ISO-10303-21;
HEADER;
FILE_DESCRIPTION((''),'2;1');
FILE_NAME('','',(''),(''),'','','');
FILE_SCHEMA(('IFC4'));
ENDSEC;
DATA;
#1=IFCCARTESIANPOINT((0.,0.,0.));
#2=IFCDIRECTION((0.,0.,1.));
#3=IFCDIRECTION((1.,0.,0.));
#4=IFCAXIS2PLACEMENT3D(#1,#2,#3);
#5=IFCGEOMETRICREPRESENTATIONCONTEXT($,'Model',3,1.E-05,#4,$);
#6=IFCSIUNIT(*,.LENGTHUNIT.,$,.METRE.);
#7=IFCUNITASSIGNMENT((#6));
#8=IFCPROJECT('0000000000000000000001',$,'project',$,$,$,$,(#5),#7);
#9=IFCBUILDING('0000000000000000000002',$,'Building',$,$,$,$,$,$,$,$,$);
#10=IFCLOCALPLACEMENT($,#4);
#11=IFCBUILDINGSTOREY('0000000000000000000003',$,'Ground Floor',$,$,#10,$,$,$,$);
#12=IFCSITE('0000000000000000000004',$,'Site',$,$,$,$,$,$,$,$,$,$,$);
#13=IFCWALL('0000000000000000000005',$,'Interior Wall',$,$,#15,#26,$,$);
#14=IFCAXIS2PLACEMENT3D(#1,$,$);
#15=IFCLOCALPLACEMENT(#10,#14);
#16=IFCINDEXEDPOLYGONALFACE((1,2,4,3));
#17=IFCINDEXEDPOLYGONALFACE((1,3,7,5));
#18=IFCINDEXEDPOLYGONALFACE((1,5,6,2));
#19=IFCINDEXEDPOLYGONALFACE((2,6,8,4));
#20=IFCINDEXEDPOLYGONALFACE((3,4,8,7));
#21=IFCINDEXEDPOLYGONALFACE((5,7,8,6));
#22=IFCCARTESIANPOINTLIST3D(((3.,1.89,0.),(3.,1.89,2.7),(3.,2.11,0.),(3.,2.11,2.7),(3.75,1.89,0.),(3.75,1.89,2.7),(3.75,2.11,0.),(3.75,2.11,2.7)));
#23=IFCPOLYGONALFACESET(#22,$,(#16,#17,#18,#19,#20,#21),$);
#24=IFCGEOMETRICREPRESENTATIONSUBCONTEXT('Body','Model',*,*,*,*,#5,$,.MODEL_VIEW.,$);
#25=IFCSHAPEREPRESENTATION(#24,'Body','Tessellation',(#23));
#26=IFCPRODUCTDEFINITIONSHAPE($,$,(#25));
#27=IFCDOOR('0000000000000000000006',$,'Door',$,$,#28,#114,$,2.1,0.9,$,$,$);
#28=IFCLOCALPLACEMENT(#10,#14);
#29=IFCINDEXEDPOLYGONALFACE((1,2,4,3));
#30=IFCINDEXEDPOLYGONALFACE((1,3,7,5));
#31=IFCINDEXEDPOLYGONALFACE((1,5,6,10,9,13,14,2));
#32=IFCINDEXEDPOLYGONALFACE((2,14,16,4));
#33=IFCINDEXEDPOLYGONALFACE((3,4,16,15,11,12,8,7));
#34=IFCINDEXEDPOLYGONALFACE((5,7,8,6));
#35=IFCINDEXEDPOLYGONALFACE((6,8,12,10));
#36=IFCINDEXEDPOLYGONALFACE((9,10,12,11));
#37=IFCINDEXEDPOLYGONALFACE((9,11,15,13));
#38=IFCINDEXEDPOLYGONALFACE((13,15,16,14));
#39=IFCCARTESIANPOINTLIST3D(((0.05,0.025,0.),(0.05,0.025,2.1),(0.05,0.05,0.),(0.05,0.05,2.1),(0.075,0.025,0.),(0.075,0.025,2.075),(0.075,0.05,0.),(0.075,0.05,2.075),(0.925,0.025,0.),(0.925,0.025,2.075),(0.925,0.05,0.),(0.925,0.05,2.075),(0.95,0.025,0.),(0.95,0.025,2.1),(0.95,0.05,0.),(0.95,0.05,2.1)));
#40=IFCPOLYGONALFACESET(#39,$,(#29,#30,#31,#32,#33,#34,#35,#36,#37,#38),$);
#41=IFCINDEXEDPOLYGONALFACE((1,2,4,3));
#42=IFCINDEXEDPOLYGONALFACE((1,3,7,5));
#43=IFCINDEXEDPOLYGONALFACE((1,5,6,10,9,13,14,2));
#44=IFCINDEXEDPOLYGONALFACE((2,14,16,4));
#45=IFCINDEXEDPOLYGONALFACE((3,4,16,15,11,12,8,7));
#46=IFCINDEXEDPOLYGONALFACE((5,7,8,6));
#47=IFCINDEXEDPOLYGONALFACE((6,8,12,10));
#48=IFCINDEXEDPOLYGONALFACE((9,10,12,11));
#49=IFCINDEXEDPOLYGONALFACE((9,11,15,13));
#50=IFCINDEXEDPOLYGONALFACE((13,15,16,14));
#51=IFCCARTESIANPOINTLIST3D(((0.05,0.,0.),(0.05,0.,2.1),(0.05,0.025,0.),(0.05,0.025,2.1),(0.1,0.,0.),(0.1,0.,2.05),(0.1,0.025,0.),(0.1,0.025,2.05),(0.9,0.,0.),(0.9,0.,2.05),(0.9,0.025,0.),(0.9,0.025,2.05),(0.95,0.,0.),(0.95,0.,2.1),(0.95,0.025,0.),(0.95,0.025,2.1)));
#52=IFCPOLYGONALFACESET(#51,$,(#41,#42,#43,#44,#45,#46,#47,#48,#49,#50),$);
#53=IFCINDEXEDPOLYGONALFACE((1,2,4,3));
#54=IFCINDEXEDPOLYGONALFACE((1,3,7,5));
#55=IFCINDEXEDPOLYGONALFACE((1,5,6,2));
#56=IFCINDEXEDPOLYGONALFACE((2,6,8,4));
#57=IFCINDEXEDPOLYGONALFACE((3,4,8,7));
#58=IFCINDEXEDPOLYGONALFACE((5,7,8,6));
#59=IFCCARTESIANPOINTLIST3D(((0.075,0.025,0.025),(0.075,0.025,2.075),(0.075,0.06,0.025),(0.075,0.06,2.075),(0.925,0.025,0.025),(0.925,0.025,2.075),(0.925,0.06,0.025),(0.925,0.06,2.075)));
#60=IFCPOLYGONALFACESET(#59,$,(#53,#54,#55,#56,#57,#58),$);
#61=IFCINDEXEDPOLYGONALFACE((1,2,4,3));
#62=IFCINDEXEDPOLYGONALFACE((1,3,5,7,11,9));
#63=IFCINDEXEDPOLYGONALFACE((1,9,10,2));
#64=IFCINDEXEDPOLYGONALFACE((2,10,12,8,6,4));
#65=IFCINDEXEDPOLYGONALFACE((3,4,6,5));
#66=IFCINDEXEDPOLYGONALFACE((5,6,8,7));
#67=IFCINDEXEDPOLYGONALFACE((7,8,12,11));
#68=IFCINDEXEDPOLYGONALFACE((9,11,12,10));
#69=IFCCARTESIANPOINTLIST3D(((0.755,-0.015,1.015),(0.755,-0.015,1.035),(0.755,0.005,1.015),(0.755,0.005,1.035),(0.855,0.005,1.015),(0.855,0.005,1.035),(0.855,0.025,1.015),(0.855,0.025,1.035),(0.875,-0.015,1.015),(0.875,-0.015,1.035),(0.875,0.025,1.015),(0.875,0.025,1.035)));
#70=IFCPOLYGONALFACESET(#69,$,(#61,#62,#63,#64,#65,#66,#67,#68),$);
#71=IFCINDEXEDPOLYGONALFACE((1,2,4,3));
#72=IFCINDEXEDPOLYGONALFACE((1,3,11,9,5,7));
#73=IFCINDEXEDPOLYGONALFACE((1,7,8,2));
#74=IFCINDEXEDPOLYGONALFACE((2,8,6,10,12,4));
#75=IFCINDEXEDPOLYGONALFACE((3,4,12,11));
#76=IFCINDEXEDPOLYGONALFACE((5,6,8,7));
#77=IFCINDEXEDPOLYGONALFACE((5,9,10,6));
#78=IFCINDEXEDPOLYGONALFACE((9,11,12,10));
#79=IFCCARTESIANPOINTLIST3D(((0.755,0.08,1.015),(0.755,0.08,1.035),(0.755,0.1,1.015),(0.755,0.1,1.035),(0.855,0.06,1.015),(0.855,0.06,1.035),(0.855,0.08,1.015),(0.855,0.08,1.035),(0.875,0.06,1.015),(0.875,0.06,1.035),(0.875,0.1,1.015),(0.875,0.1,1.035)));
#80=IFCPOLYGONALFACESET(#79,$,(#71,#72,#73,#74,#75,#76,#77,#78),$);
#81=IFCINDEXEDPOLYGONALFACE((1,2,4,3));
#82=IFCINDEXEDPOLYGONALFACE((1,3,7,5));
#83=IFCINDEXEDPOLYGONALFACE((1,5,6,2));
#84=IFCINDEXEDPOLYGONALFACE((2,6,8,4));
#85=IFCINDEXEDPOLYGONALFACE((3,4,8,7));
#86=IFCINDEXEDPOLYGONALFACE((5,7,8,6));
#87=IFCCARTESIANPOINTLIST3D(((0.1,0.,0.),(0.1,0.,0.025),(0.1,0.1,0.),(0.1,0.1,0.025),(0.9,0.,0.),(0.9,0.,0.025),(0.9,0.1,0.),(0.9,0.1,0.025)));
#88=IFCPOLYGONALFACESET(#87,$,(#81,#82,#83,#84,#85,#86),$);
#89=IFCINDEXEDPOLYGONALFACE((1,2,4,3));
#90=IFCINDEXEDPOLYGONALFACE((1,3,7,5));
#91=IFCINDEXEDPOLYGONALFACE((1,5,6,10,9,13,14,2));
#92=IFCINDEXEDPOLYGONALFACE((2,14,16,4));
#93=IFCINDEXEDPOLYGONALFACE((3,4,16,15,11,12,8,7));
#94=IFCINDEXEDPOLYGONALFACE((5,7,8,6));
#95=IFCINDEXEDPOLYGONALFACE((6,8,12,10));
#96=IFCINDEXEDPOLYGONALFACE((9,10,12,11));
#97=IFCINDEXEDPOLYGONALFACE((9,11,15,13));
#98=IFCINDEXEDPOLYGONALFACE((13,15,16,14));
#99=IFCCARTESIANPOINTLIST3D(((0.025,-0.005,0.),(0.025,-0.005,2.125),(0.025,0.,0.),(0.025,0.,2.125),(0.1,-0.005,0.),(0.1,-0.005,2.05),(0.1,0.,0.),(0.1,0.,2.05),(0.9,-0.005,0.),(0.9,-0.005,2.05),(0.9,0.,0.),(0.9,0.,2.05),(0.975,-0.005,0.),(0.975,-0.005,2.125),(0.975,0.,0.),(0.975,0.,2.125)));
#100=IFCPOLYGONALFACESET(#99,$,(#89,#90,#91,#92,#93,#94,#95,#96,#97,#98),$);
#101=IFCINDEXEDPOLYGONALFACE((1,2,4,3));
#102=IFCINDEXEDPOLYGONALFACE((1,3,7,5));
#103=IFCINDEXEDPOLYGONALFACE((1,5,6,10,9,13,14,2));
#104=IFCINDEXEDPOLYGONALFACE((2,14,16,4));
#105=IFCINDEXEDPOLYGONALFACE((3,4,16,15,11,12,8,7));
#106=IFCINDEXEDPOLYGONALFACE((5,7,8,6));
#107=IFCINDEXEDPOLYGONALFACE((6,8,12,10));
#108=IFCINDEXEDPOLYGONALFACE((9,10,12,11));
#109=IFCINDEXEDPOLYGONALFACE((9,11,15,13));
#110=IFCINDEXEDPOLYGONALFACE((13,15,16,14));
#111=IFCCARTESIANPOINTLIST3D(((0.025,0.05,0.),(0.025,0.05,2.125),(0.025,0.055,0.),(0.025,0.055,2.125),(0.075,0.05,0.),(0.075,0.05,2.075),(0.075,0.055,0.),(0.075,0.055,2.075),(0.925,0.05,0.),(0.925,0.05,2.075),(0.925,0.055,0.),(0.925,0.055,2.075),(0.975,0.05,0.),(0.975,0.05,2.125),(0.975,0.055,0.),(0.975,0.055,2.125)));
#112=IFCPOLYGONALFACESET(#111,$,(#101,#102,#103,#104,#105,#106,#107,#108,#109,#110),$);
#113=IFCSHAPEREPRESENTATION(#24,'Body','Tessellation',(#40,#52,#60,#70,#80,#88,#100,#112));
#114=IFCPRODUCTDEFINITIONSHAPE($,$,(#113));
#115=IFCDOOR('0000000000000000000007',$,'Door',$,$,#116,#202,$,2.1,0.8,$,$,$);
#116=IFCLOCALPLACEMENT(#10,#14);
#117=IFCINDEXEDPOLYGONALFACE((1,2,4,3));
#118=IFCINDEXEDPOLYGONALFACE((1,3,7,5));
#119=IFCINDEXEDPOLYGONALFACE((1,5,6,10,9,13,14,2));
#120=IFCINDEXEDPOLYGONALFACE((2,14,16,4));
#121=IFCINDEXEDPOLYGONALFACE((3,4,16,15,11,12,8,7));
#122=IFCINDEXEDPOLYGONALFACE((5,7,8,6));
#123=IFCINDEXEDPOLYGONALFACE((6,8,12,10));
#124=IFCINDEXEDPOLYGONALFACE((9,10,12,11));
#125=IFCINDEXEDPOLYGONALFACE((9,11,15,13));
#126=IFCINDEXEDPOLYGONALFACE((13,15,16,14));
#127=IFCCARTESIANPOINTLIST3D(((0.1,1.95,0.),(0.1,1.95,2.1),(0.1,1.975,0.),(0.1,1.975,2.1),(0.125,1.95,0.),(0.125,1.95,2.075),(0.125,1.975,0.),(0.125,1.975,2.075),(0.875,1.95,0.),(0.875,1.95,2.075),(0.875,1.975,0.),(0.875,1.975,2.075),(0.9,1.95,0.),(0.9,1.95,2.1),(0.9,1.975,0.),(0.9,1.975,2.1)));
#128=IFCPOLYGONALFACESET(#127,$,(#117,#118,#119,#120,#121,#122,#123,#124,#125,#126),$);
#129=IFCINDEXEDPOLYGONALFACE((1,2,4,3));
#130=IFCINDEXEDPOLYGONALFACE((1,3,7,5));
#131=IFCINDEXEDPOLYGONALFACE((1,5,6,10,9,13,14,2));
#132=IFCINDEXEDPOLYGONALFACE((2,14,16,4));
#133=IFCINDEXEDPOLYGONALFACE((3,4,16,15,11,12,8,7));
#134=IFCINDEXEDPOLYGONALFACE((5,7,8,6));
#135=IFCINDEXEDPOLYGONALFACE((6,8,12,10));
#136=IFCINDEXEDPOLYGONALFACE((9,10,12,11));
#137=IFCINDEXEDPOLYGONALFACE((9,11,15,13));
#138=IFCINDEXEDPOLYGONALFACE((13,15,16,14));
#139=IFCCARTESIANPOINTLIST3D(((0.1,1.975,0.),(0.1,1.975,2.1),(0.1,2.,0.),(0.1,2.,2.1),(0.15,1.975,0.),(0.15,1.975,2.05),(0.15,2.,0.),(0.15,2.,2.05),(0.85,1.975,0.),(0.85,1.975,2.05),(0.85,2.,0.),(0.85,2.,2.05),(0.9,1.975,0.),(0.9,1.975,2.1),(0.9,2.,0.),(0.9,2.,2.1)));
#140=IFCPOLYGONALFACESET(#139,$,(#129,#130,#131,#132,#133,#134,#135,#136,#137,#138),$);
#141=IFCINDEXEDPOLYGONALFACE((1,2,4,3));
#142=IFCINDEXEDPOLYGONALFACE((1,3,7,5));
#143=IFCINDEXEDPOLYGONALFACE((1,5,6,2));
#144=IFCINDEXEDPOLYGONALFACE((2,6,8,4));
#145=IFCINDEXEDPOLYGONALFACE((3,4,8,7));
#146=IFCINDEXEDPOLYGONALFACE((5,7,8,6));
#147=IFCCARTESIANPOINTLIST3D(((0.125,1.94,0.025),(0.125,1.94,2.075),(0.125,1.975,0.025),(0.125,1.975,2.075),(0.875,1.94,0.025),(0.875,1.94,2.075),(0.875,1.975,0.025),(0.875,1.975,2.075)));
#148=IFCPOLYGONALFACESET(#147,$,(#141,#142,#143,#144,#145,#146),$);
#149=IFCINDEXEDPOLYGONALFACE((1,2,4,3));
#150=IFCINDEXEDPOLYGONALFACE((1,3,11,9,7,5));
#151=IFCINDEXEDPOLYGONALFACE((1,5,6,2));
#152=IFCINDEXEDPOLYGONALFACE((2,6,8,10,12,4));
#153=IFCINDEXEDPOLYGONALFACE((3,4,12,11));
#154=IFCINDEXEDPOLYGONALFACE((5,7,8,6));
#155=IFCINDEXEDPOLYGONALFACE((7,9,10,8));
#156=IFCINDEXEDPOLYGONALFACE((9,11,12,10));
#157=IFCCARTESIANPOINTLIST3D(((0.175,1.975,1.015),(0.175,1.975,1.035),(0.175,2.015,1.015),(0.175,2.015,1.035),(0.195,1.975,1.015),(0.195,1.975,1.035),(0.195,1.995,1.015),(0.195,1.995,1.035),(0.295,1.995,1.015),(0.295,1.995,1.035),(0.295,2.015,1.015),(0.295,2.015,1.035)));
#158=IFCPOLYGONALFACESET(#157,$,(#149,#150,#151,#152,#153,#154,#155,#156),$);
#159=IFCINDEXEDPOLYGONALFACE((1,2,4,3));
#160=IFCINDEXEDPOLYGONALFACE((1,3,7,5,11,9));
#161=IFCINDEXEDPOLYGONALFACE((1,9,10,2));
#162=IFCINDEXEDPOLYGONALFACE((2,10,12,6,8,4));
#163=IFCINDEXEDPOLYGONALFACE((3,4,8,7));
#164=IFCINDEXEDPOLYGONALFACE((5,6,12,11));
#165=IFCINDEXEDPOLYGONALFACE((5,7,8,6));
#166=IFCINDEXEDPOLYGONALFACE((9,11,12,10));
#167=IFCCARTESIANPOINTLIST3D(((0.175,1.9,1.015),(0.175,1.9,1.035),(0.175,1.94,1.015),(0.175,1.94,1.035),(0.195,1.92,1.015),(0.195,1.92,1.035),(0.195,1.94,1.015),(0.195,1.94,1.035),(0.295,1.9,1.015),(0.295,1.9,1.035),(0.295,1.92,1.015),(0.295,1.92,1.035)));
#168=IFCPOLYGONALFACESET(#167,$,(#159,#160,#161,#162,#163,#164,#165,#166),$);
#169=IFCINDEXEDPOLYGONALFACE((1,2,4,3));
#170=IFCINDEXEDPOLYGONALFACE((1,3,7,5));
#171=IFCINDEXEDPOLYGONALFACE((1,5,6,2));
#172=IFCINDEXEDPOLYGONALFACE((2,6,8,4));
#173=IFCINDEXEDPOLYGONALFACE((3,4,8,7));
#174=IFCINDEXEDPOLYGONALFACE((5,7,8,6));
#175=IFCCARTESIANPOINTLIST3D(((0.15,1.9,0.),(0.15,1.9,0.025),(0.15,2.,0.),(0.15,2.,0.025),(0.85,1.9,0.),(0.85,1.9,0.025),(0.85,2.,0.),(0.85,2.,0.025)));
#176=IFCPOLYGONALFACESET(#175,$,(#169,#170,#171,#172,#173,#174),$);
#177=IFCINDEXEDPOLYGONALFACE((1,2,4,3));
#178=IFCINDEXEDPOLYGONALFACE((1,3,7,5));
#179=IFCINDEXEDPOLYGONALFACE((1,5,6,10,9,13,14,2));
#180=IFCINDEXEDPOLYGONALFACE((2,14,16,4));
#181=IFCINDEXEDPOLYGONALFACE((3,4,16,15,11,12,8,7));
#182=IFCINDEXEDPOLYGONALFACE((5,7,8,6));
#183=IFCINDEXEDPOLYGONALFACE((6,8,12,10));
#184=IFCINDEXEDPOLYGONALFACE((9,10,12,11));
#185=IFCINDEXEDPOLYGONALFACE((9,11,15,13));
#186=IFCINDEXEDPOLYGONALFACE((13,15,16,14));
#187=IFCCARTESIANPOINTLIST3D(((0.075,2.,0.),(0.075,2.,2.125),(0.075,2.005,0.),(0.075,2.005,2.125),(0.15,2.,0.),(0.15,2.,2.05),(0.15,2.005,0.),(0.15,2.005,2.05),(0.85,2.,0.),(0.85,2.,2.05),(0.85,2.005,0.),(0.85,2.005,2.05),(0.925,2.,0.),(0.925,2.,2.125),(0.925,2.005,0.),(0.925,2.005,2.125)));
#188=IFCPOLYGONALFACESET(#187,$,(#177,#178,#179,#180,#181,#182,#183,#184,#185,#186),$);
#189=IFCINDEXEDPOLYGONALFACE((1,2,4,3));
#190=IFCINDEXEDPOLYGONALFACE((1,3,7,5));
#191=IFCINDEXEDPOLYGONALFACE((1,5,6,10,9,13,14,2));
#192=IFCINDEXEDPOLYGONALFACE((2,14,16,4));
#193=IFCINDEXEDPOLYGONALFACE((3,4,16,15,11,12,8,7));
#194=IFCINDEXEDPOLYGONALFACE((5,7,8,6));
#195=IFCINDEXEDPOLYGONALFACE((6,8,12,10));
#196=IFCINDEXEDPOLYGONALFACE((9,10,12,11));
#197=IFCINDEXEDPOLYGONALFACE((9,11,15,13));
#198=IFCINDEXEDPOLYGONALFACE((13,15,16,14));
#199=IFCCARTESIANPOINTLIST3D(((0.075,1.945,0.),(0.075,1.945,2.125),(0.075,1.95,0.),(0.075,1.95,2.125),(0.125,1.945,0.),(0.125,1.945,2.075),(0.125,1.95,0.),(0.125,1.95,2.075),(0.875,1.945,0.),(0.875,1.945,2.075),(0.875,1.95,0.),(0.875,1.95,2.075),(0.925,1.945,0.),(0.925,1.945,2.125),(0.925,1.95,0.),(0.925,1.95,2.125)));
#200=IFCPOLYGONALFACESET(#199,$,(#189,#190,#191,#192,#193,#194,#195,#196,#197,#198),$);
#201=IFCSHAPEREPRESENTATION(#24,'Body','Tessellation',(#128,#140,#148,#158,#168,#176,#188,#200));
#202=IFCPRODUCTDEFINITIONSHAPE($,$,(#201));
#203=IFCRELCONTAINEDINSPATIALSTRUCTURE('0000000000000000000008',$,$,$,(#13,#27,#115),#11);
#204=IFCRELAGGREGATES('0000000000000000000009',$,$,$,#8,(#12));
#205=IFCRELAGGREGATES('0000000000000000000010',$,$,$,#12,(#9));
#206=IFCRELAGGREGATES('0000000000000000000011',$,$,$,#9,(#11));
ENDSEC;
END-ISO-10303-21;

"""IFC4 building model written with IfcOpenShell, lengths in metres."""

from ifc_helpers import new_model, si_unit, frame, origin_with_axes, place, context, subcontext, project, spatial, line, indexed_curve, outline, extrude, element, save


model = new_model("IFC4")

# Units and contexts
model_context = context("Model", 3, precision=1e-05, world=origin_with_axes())
body_context = subcontext(model_context, "Body", "Model", "MODEL_VIEW")
ifc_project = project(units=[si_unit("LENGTHUNIT", "METRE")], contexts=[model_context])

# Site, building, storey
site = spatial("IfcSite", under=ifc_project, Name="Site")
building = spatial("IfcBuilding", under=site, Name="Building")
storey_placement = place(None, origin_with_axes())
storey = spatial("IfcBuildingStorey", under=building, at=storey_placement, Name="Ground Floor")

# Wall
for number, where, z_axis, x_axis, name in (
    (1, (3.75, 2.0, 0.0), (0.0, 0.0, 1.0), (-1.0, 0.0, 0.0), "Interior Wall"),
):
    element("IfcWall", number, at=place(storey_placement, frame(where, z_axis=z_axis, x_axis=x_axis)), inside=storey, Name=name, context=body_context, shape_type="SweptSolid", body=[
        extrude(outline(indexed_curve([(0.0, 0.0), (0.0, 0.22), (0.75, 0.22), (0.75, 0.0), (0.0, 0.0)], self_intersect=False)), frame((0.0, -0.11, 0.0), z_axis=(0.0, 0.0, 1.0), x_axis=(1.0, 0.0, 0.0)), (0.0, 0.0, 1.0), 2.7),
    ])

# Doors
door_1_placement = place(storey_placement, frame((0.05, 0.0, 0.0), z_axis=(0.0, 0.0, 1.0), x_axis=(1.0, 0.0, 0.0)))
element("IfcDoor", 2, at=door_1_placement, inside=storey, Name="Door", OverallHeight=2.1, OverallWidth=0.9, context=body_context, shape_type="SweptSolid", body=[
    extrude(outline(indexed_curve([(0.0, 0.0), (0.0, 2.1), (0.9, 2.1), (0.9, 0.0), (0.875, 0.0), (0.875, 2.075), (0.025, 2.075), (0.025, 0.0)], segments=[line(1, 2, 3, 4, 5, 6, 7, 8, 1)])), frame((0.0, 0.025, 0.0), z_axis=(0.0, -1.0, 0.0), x_axis=(1.0, 0.0, 0.0)), (0.0, 0.0, -1.0), 0.025),
    extrude(outline(indexed_curve([(0.0, 0.0), (0.0, 2.1), (0.9, 2.1), (0.9, 0.0), (0.85, 0.0), (0.85, 2.05), (0.05, 2.05), (0.05, 0.0)], segments=[line(1, 2, 3, 4, 5, 6, 7, 8, 1)])), frame((0.0, 0.0, 0.0), z_axis=(0.0, -1.0, 0.0), x_axis=(1.0, 0.0, 0.0)), (0.0, 0.0, -1.0), 0.025),
    extrude(outline(indexed_curve([(0.0, 0.0), (0.85, 0.0), (0.85, 0.035), (0.0, 0.035)], segments=[line(1, 2, 3, 4, 1)])), frame((0.025, 0.025, 0.025), z_axis=(0.0, 0.0, 1.0), x_axis=(1.0, 0.0, 0.0)), (0.0, 0.0, 1.0), 2.05),
    extrude(outline(indexed_curve([(0.0, 0.0), (0.0, -0.04), (-0.12, -0.04), (-0.12, -0.02), (-0.02, -0.02), (-0.02, 0.0)], segments=[line(1, 2, 3, 4, 5, 6, 1)])), frame((0.825, 0.025, 1.015), z_axis=(0.0, 0.0, 1.0), x_axis=(1.0, 0.0, 0.0)), (0.0, 0.0, 1.0), 0.02),
    extrude(outline(indexed_curve([(0.0, 0.0), (0.0, 0.04), (-0.12, 0.04), (-0.12, 0.02), (-0.02, 0.02), (-0.02, 0.0)], segments=[line(1, 2, 3, 4, 5, 6, 1)])), frame((0.825, 0.06, 1.015), z_axis=(0.0, 0.0, 1.0), x_axis=(1.0, 0.0, 0.0)), (0.0, 0.0, 1.0), 0.02),
    extrude(outline(indexed_curve([(0.0, 0.0), (0.8, 0.0), (0.8, 0.1), (0.0, 0.1)], segments=[line(1, 2, 3, 4, 1)])), frame((0.05, 0.0, 0.0), z_axis=(0.0, 0.0, 1.0), x_axis=(1.0, 0.0, 0.0)), (0.0, 0.0, 1.0), 0.025),
    extrude(outline(indexed_curve([(0.0, 0.0), (0.0, 2.125), (0.95, 2.125), (0.95, 0.0), (0.875, 0.0), (0.875, 2.05), (0.075, 2.05), (0.075, 0.0)], segments=[line(1, 2, 3, 4, 5, 6, 7, 8, 1)])), frame((-0.025, -0.005, 0.0), z_axis=(0.0, -1.0, 0.0), x_axis=(1.0, 0.0, 0.0)), (0.0, 0.0, -1.0), 0.005),
    extrude(outline(indexed_curve([(0.0, 0.0), (0.0, 2.125), (0.95, 2.125), (0.95, 0.0), (0.9, 0.0), (0.9, 2.075), (0.05, 2.075), (0.05, 0.0)], segments=[line(1, 2, 3, 4, 5, 6, 7, 8, 1)])), frame((-0.025, 0.05, 0.0), z_axis=(0.0, -1.0, 0.0), x_axis=(1.0, 0.0, 0.0)), (0.0, 0.0, -1.0), 0.005),
])
door_2_placement = place(storey_placement, frame((0.9, 2.0, 0.0), z_axis=(0.0, 0.0, 1.0), x_axis=(-1.0, 0.0, 0.0)))
element("IfcDoor", 3, at=door_2_placement, inside=storey, Name="Door", OverallHeight=2.1, OverallWidth=0.8, context=body_context, shape_type="SweptSolid", body=[
    extrude(outline(indexed_curve([(0.0, 0.0), (0.0, 2.1), (0.8, 2.1), (0.8, 0.0), (0.775, 0.0), (0.775, 2.075), (0.025, 2.075), (0.025, 0.0)], segments=[line(1, 2, 3, 4, 5, 6, 7, 8, 1)])), frame((0.0, 0.025, 0.0), z_axis=(0.0, -1.0, 0.0), x_axis=(1.0, 0.0, 0.0)), (0.0, 0.0, -1.0), 0.025),
    extrude(outline(indexed_curve([(0.0, 0.0), (0.0, 2.1), (0.8, 2.1), (0.8, 0.0), (0.75, 0.0), (0.75, 2.05), (0.05, 2.05), (0.05, 0.0)], segments=[line(1, 2, 3, 4, 5, 6, 7, 8, 1)])), frame((0.0, 0.0, 0.0), z_axis=(0.0, -1.0, 0.0), x_axis=(1.0, 0.0, 0.0)), (0.0, 0.0, -1.0), 0.025),
    extrude(outline(indexed_curve([(0.0, 0.0), (0.75, 0.0), (0.75, 0.035), (0.0, 0.035)], segments=[line(1, 2, 3, 4, 1)])), frame((0.025, 0.025, 0.025), z_axis=(0.0, 0.0, 1.0), x_axis=(1.0, 0.0, 0.0)), (0.0, 0.0, 1.0), 2.05),
    extrude(outline(indexed_curve([(0.0, 0.0), (0.0, -0.04), (-0.12, -0.04), (-0.12, -0.02), (-0.02, -0.02), (-0.02, 0.0)], segments=[line(1, 2, 3, 4, 5, 6, 1)])), frame((0.725, 0.025, 1.015), z_axis=(0.0, 0.0, 1.0), x_axis=(1.0, 0.0, 0.0)), (0.0, 0.0, 1.0), 0.02),
    extrude(outline(indexed_curve([(0.0, 0.0), (0.0, 0.04), (-0.12, 0.04), (-0.12, 0.02), (-0.02, 0.02), (-0.02, 0.0)], segments=[line(1, 2, 3, 4, 5, 6, 1)])), frame((0.725, 0.06, 1.015), z_axis=(0.0, 0.0, 1.0), x_axis=(1.0, 0.0, 0.0)), (0.0, 0.0, 1.0), 0.02),
    extrude(outline(indexed_curve([(0.0, 0.0), (0.7, 0.0), (0.7, 0.1), (0.0, 0.1)], segments=[line(1, 2, 3, 4, 1)])), frame((0.05, 0.0, 0.0), z_axis=(0.0, 0.0, 1.0), x_axis=(1.0, 0.0, 0.0)), (0.0, 0.0, 1.0), 0.025),
    extrude(outline(indexed_curve([(0.0, 0.0), (0.0, 2.125), (0.85, 2.125), (0.85, 0.0), (0.775, 0.0), (0.775, 2.05), (0.075, 2.05), (0.075, 0.0)], segments=[line(1, 2, 3, 4, 5, 6, 7, 8, 1)])), frame((-0.025, -0.005, 0.0), z_axis=(0.0, -1.0, 0.0), x_axis=(1.0, 0.0, 0.0)), (0.0, 0.0, -1.0), 0.005),
    extrude(outline(indexed_curve([(0.0, 0.0), (0.0, 2.125), (0.85, 2.125), (0.85, 0.0), (0.8, 0.0), (0.8, 2.075), (0.05, 2.075), (0.05, 0.0)], segments=[line(1, 2, 3, 4, 5, 6, 7, 8, 1)])), frame((-0.025, 0.05, 0.0), z_axis=(0.0, -1.0, 0.0), x_axis=(1.0, 0.0, 0.0)), (0.0, 0.0, -1.0), 0.005),
])

save(model, "model.ifc")
